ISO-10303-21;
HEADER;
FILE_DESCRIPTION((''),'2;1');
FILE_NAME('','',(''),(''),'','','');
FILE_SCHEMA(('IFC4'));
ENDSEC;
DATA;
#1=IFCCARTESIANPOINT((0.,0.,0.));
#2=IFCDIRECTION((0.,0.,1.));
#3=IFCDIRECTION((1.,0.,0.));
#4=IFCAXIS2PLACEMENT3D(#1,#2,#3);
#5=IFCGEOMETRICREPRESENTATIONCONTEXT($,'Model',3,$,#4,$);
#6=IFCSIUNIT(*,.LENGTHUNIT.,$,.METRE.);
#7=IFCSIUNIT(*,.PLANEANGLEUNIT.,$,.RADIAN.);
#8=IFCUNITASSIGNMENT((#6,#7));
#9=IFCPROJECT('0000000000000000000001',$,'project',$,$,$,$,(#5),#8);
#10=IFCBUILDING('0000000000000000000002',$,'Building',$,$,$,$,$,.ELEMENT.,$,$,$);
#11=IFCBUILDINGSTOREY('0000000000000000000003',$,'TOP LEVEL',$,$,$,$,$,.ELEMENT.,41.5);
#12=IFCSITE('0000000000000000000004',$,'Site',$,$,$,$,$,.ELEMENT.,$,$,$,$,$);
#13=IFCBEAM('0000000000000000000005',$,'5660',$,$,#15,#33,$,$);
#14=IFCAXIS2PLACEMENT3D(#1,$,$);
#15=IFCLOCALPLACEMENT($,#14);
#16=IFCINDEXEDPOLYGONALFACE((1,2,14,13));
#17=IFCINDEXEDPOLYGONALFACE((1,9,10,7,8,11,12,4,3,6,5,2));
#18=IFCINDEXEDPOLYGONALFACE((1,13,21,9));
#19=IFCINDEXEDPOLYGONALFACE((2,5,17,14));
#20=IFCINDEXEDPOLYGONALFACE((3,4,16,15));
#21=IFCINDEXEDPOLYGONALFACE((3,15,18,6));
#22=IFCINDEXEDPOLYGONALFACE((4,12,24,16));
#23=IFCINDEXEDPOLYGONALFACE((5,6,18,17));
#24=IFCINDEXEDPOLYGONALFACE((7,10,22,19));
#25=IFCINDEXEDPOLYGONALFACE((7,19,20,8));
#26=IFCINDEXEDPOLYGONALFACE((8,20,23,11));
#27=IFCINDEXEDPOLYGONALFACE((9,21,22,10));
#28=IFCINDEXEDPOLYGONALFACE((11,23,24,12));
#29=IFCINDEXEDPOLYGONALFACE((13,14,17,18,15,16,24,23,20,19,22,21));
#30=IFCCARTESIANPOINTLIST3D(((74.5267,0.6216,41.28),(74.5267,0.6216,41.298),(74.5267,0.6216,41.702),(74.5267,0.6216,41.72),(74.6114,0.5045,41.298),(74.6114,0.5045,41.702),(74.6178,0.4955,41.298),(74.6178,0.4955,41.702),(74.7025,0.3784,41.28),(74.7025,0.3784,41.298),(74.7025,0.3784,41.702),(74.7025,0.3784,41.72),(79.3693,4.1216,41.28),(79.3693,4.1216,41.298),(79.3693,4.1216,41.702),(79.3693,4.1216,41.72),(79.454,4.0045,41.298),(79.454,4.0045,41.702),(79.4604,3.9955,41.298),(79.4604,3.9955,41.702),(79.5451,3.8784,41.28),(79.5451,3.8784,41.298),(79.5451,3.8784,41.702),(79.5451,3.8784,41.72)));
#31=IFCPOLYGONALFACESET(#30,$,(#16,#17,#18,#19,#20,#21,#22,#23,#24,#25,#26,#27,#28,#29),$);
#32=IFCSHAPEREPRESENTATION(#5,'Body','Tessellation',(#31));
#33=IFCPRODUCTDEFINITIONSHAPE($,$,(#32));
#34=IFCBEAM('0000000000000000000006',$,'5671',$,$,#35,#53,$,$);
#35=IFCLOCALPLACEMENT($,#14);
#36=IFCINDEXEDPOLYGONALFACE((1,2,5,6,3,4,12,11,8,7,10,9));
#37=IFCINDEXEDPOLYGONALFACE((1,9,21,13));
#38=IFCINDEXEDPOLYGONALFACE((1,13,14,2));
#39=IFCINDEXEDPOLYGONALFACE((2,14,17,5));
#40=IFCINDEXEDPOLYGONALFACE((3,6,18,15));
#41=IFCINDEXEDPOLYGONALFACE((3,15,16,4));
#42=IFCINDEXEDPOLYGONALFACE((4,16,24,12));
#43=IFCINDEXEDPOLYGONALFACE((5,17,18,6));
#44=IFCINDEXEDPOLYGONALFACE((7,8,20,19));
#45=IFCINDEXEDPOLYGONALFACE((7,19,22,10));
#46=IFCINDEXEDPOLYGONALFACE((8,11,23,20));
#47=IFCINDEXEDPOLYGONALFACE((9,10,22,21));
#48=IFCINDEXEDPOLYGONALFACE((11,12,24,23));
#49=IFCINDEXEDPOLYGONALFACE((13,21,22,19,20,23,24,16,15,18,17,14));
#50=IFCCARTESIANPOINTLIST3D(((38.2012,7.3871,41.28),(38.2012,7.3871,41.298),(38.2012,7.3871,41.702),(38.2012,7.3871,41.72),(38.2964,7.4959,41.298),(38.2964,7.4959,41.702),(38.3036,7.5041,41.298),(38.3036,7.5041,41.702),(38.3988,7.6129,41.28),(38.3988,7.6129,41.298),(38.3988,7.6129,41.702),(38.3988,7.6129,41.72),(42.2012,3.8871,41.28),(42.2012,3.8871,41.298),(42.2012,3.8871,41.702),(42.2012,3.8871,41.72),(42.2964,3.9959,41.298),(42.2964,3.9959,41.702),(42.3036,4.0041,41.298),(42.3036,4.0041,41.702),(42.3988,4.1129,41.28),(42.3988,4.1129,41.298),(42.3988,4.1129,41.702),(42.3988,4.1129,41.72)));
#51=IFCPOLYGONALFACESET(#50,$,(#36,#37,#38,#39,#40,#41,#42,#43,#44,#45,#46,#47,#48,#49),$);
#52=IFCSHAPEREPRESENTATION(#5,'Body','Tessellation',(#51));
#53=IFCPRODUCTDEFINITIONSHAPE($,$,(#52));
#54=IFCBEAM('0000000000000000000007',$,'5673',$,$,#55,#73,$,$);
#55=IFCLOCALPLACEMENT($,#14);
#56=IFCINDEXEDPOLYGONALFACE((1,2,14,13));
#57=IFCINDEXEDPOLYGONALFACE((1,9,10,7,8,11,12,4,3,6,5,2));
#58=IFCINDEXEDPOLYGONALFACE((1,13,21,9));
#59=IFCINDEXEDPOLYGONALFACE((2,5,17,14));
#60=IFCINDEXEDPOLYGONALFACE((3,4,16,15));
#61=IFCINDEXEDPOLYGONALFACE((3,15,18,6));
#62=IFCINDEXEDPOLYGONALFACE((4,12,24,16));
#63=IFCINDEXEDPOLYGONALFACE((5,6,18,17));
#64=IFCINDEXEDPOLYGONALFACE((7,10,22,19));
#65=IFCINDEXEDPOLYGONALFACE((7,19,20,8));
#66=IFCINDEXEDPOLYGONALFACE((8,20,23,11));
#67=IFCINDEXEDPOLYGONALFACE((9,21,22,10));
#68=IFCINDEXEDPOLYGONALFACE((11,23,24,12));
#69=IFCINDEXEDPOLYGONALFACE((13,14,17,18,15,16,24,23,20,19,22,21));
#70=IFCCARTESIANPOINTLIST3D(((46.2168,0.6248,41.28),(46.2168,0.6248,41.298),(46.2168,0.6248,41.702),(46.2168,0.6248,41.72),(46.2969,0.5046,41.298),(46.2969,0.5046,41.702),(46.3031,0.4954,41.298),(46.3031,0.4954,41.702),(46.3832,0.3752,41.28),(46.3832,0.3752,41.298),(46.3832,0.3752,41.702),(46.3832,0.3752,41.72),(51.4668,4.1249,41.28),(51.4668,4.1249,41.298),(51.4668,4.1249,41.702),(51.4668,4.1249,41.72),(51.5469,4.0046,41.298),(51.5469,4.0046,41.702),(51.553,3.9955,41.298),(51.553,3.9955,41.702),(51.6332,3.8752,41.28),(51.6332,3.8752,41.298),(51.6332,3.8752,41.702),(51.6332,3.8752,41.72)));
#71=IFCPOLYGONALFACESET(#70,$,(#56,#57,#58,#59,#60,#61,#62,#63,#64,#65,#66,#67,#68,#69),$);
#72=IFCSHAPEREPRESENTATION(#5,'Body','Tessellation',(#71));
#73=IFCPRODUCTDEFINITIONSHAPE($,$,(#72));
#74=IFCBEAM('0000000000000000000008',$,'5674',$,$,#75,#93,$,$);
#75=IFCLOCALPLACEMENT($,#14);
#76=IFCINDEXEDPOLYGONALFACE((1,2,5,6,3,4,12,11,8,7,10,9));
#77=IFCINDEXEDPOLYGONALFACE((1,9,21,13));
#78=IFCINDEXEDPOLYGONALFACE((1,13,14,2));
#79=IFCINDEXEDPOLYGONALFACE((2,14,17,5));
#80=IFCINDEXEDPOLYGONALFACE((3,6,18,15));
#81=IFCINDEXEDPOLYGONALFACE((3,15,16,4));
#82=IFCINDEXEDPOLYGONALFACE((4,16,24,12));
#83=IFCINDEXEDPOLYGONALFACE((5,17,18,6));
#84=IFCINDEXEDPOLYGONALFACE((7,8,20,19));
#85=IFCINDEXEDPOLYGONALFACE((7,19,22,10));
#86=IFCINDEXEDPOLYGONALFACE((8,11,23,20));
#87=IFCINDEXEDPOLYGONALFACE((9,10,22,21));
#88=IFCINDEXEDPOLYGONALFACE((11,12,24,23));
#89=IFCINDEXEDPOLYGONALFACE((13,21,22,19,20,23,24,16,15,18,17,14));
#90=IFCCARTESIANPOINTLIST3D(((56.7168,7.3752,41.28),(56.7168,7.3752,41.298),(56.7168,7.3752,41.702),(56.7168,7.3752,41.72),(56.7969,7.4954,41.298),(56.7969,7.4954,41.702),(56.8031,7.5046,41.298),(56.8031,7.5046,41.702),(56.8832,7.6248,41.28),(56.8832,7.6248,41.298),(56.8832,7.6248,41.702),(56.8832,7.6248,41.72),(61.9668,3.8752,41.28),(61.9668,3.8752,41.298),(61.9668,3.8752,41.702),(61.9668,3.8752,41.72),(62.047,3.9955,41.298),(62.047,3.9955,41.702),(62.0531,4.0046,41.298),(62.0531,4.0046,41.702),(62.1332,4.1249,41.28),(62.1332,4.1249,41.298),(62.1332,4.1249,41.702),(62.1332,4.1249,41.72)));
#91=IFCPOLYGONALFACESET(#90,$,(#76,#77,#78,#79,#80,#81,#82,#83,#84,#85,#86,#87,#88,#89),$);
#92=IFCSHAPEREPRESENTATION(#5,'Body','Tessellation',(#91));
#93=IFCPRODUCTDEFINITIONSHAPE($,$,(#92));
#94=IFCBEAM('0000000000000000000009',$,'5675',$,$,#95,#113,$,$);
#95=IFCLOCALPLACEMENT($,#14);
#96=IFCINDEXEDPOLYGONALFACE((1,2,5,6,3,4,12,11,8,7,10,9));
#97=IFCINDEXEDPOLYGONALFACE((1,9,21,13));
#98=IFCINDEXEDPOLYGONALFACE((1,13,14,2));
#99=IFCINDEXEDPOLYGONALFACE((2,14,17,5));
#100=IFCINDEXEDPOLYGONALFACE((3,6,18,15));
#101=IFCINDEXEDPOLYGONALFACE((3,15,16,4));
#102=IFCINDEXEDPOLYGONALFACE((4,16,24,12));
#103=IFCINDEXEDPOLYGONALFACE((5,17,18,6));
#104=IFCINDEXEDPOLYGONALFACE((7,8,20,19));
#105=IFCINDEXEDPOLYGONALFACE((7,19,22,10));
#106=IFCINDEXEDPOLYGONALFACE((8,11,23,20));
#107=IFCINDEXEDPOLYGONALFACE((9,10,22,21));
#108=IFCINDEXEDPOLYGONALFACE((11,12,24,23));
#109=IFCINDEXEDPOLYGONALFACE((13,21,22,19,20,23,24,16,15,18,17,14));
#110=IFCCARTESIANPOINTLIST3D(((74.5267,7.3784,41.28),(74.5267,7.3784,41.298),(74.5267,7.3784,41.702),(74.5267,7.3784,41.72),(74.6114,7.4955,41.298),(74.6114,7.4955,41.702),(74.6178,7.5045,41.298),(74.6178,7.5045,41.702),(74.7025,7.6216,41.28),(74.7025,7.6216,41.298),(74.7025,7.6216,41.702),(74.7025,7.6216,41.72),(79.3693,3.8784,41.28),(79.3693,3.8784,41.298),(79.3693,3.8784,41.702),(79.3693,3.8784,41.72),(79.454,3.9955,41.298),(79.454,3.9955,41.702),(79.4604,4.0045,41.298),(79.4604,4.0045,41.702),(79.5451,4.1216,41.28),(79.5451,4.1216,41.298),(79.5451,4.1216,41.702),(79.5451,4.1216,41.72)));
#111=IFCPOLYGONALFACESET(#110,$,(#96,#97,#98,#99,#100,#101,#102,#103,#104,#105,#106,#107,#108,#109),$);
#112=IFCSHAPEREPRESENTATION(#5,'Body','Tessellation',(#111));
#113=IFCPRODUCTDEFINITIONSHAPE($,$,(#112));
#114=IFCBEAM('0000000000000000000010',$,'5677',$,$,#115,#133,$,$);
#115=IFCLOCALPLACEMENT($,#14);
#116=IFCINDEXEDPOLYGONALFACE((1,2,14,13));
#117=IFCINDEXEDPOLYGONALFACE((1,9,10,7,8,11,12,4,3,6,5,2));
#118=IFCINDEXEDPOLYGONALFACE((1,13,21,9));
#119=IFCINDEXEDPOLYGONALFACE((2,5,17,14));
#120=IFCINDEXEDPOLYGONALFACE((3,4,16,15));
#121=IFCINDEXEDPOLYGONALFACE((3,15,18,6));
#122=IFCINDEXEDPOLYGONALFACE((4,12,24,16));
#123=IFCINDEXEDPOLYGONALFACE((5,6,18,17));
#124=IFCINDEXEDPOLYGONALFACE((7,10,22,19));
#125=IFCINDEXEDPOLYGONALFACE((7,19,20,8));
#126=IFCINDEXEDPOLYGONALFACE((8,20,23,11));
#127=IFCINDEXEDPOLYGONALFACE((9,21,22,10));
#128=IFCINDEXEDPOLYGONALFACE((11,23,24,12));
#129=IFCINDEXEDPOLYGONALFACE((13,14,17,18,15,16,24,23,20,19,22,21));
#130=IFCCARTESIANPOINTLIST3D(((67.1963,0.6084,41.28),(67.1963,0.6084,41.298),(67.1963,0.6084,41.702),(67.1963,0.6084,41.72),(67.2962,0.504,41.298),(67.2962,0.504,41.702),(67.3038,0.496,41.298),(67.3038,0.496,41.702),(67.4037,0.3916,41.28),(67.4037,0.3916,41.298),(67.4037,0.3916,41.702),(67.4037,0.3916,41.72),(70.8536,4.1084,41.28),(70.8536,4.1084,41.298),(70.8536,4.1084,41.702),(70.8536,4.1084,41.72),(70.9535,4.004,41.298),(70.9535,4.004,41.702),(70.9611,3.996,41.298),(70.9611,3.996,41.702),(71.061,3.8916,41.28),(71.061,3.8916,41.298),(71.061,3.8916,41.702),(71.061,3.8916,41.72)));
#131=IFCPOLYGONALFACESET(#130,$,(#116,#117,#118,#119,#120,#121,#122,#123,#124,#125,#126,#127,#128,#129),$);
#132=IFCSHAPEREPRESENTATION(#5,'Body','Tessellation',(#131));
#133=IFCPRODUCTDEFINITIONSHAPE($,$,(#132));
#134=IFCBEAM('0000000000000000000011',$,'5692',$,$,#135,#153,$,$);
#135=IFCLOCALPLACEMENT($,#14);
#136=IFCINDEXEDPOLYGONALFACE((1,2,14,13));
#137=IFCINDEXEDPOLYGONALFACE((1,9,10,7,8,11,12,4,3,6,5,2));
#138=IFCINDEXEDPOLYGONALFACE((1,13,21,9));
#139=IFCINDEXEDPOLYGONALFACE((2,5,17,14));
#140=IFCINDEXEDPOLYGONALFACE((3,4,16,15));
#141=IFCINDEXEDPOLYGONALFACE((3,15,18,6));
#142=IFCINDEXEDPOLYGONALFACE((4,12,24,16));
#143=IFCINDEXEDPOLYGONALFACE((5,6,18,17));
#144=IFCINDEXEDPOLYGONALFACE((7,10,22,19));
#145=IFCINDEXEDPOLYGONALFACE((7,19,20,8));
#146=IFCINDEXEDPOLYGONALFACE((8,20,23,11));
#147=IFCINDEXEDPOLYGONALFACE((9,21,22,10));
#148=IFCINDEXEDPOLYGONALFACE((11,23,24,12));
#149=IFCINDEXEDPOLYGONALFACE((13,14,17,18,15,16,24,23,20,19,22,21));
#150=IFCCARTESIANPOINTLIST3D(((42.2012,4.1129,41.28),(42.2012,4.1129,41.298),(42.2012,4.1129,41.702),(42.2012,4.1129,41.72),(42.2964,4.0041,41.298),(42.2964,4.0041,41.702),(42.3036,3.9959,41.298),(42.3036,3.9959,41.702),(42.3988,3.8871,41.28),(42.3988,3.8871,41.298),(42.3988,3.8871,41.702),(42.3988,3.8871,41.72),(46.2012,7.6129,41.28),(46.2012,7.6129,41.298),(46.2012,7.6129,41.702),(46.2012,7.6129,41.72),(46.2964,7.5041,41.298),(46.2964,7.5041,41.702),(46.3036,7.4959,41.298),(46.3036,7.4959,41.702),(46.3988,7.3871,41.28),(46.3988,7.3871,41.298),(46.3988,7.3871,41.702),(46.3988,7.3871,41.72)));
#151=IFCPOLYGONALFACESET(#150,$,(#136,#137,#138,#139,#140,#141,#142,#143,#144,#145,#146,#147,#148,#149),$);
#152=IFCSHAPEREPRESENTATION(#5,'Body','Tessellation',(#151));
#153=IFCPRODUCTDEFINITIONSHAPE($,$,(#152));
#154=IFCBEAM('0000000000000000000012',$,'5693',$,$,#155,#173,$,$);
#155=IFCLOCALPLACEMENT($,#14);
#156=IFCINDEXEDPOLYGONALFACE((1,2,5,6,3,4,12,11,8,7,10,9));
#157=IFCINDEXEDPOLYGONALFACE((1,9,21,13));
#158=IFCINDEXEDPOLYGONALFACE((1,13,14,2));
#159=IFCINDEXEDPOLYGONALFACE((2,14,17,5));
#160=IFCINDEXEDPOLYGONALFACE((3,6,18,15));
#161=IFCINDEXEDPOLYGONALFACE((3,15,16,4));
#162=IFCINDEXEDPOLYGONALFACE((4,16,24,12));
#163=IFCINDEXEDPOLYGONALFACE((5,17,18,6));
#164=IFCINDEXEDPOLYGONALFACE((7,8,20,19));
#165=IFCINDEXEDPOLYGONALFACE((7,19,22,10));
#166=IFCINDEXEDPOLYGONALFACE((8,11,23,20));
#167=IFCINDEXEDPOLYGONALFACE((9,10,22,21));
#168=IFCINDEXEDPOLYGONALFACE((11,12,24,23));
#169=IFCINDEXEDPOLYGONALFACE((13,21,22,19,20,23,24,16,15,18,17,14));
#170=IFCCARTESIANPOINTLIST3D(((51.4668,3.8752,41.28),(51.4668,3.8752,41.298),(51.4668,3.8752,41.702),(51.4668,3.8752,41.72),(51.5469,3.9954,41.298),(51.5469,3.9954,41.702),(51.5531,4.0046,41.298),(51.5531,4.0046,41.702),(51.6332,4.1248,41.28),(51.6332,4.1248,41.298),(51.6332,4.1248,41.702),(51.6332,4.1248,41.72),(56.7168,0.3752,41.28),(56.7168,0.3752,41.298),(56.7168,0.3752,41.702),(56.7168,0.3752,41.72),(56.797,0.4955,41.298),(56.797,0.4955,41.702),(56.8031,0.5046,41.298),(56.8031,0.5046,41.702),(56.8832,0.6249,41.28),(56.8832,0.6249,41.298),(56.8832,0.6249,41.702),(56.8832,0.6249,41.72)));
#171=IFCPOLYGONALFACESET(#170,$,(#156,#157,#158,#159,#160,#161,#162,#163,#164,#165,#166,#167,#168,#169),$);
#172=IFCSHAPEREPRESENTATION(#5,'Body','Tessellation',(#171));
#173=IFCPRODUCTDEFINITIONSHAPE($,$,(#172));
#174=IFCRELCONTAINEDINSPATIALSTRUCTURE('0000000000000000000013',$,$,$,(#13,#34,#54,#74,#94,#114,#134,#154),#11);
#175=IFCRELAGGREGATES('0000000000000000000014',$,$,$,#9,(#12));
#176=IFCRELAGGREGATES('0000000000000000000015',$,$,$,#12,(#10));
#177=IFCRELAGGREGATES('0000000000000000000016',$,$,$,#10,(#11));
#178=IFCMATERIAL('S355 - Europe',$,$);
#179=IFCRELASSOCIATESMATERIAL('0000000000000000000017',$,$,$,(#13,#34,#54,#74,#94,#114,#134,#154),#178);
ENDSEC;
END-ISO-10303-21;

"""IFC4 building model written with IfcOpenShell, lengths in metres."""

from ifc_helpers import new_model, si_unit, frame, origin_with_axes, origin_2d_with_axis, place, context, project, spatial, i_section, extrude, material, material_profile, profile_set, profile_usage, element, save


model = new_model("IFC4")

# Units and contexts
model_context = context("Model", 3, world=origin_with_axes())
ifc_project = project(units=[si_unit("LENGTHUNIT", "METRE"), si_unit("PLANEANGLEUNIT", "RADIAN")], contexts=[model_context])

# Site, building, storey
site = spatial("IfcSite", under=ifc_project, Name="Site", CompositionType="ELEMENT")
building = spatial("IfcBuilding", under=site, Name="Building", CompositionType="ELEMENT")
storey = spatial("IfcBuildingStorey", under=building, Name="TOP LEVEL", CompositionType="ELEMENT", Elevation=41.5)

# Beams
ifc_material = material(Name="S355 - Europe")
ifc_material_profile_1 = material_profile(ifc_material, i_section(OverallWidth=0.3, OverallDepth=0.44, WebThickness=0.011, FlangeThickness=0.018, at=origin_2d_with_axis()))
ifc_profile_set_1 = profile_set([ifc_material_profile_1])
ifc_profile_usage_1 = profile_usage(ifc_profile_set_1, cardinal=10)
beam_1_placement = place(None, frame((74.6146, 0.5, 41.5), z_axis=(0.810475, 0.585773, 0.0), x_axis=(-0.585773, 0.810475, 0.0)))
element("IfcBeam", 1, at=beam_1_placement, inside=storey, material=ifc_profile_usage_1, Name="5660", context=model_context, shape_type="SweptSolid", body=[
    extrude(i_section(OverallWidth=0.3, OverallDepth=0.44, WebThickness=0.011, FlangeThickness=0.018, at=origin_2d_with_axis()), origin_with_axes(), (0.0, 0.0, 1.0), 5.975),
])
ifc_material_profile_2 = material_profile(ifc_material, i_section(OverallWidth=0.3, OverallDepth=0.44, WebThickness=0.011, FlangeThickness=0.018, at=origin_2d_with_axis()))
ifc_profile_set_2 = profile_set([ifc_material_profile_2])
ifc_profile_usage_2 = profile_usage(ifc_profile_set_2, cardinal=10)
beam_2_placement = place(None, frame((38.3, 7.5, 41.5), z_axis=(0.752577, -0.658505, 0.0), x_axis=(0.658505, 0.752577, 0.0)))
element("IfcBeam", 2, at=beam_2_placement, inside=storey, material=ifc_profile_usage_2, Name="5671", context=model_context, shape_type="SweptSolid", body=[
    extrude(i_section(OverallWidth=0.3, OverallDepth=0.44, WebThickness=0.011, FlangeThickness=0.018, at=origin_2d_with_axis()), origin_with_axes(), (0.0, 0.0, 1.0), 5.3151),
])
ifc_material_profile_3 = material_profile(ifc_material, i_section(OverallWidth=0.3, OverallDepth=0.44, WebThickness=0.011, FlangeThickness=0.018, at=origin_2d_with_axis()))
ifc_profile_set_3 = profile_set([ifc_material_profile_3])
ifc_profile_usage_3 = profile_usage(ifc_profile_set_3, cardinal=10)
beam_3_placement = place(None, frame((46.3, 0.5, 41.5), z_axis=(0.832045, 0.554708, 0.0), x_axis=(-0.554708, 0.832045, 0.0)))
element("IfcBeam", 3, at=beam_3_placement, inside=storey, material=ifc_profile_usage_3, Name="5673", context=model_context, shape_type="SweptSolid", body=[
    extrude(i_section(OverallWidth=0.3, OverallDepth=0.44, WebThickness=0.011, FlangeThickness=0.018, at=origin_2d_with_axis()), origin_with_axes(), (0.0, 0.0, 1.0), 6.3097),
])
ifc_material_profile_4 = material_profile(ifc_material, i_section(OverallWidth=0.3, OverallDepth=0.44, WebThickness=0.011, FlangeThickness=0.018, at=origin_2d_with_axis()))
ifc_profile_set_4 = profile_set([ifc_material_profile_4])
ifc_profile_usage_4 = profile_usage(ifc_profile_set_4, cardinal=10)
beam_4_placement = place(None, frame((56.8, 7.5, 41.5), z_axis=(0.832055, -0.554693, 0.0), x_axis=(0.554693, 0.832055, 0.0)))
element("IfcBeam", 4, at=beam_4_placement, inside=storey, material=ifc_profile_usage_4, Name="5674", context=model_context, shape_type="SweptSolid", body=[
    extrude(i_section(OverallWidth=0.3, OverallDepth=0.44, WebThickness=0.011, FlangeThickness=0.018, at=origin_2d_with_axis()), origin_with_axes(), (0.0, 0.0, 1.0), 6.3097),
])
ifc_material_profile_5 = material_profile(ifc_material, i_section(OverallWidth=0.3, OverallDepth=0.44, WebThickness=0.011, FlangeThickness=0.018, at=origin_2d_with_axis()))
ifc_profile_set_5 = profile_set([ifc_material_profile_5])
ifc_profile_usage_5 = profile_usage(ifc_profile_set_5, cardinal=10)
beam_5_placement = place(None, frame((74.6146, 7.5, 41.5), z_axis=(0.810475, -0.585773, 0.0), x_axis=(0.585773, 0.810475, 0.0)))
element("IfcBeam", 5, at=beam_5_placement, inside=storey, material=ifc_profile_usage_5, Name="5675", context=model_context, shape_type="SweptSolid", body=[
    extrude(i_section(OverallWidth=0.3, OverallDepth=0.44, WebThickness=0.011, FlangeThickness=0.018, at=origin_2d_with_axis()), origin_with_axes(), (0.0, 0.0, 1.0), 5.975),
])
ifc_material_profile_6 = material_profile(ifc_material, i_section(OverallWidth=0.3, OverallDepth=0.44, WebThickness=0.011, FlangeThickness=0.018, at=origin_2d_with_axis()))
ifc_profile_set_6 = profile_set([ifc_material_profile_6])
ifc_profile_usage_6 = profile_usage(ifc_profile_set_6, cardinal=10)
beam_6_placement = place(None, frame((67.3, 0.5, 41.5), z_axis=(0.722473, 0.691399, 0.0), x_axis=(-0.691399, 0.722473, 0.0)))
element("IfcBeam", 6, at=beam_6_placement, inside=storey, material=ifc_profile_usage_6, Name="5677", context=model_context, shape_type="SweptSolid", body=[
    extrude(i_section(OverallWidth=0.3, OverallDepth=0.44, WebThickness=0.011, FlangeThickness=0.018, at=origin_2d_with_axis()), origin_with_axes(), (0.0, 0.0, 1.0), 5.0622),
])
ifc_material_profile_7 = material_profile(ifc_material, i_section(OverallWidth=0.3, OverallDepth=0.44, WebThickness=0.011, FlangeThickness=0.018, at=origin_2d_with_axis()))
ifc_profile_set_7 = profile_set([ifc_material_profile_7])
ifc_profile_usage_7 = profile_usage(ifc_profile_set_7, cardinal=10)
beam_7_placement = place(None, frame((42.3, 4.0, 41.5), z_axis=(0.752577, 0.658505, 0.0), x_axis=(-0.658505, 0.752577, 0.0)))
element("IfcBeam", 7, at=beam_7_placement, inside=storey, material=ifc_profile_usage_7, Name="5692", context=model_context, shape_type="SweptSolid", body=[
    extrude(i_section(OverallWidth=0.3, OverallDepth=0.44, WebThickness=0.011, FlangeThickness=0.018, at=origin_2d_with_axis()), origin_with_axes(), (0.0, 0.0, 1.0), 5.3151),
])
ifc_material_profile_8 = material_profile(ifc_material, i_section(OverallWidth=0.3, OverallDepth=0.44, WebThickness=0.011, FlangeThickness=0.018, at=origin_2d_with_axis()))
ifc_profile_set_8 = profile_set([ifc_material_profile_8])
ifc_profile_usage_8 = profile_usage(ifc_profile_set_8, cardinal=10)
beam_8_placement = place(None, frame((51.55, 4.0, 41.5), z_axis=(0.832055, -0.554693, 0.0), x_axis=(0.554693, 0.832055, 0.0)))
element("IfcBeam", 8, at=beam_8_placement, inside=storey, material=ifc_profile_usage_8, Name="5693", context=model_context, shape_type="SweptSolid", body=[
    extrude(i_section(OverallWidth=0.3, OverallDepth=0.44, WebThickness=0.011, FlangeThickness=0.018, at=origin_2d_with_axis()), origin_with_axes(), (0.0, 0.0, 1.0), 6.3097),
])

save(model, "model.ifc")
